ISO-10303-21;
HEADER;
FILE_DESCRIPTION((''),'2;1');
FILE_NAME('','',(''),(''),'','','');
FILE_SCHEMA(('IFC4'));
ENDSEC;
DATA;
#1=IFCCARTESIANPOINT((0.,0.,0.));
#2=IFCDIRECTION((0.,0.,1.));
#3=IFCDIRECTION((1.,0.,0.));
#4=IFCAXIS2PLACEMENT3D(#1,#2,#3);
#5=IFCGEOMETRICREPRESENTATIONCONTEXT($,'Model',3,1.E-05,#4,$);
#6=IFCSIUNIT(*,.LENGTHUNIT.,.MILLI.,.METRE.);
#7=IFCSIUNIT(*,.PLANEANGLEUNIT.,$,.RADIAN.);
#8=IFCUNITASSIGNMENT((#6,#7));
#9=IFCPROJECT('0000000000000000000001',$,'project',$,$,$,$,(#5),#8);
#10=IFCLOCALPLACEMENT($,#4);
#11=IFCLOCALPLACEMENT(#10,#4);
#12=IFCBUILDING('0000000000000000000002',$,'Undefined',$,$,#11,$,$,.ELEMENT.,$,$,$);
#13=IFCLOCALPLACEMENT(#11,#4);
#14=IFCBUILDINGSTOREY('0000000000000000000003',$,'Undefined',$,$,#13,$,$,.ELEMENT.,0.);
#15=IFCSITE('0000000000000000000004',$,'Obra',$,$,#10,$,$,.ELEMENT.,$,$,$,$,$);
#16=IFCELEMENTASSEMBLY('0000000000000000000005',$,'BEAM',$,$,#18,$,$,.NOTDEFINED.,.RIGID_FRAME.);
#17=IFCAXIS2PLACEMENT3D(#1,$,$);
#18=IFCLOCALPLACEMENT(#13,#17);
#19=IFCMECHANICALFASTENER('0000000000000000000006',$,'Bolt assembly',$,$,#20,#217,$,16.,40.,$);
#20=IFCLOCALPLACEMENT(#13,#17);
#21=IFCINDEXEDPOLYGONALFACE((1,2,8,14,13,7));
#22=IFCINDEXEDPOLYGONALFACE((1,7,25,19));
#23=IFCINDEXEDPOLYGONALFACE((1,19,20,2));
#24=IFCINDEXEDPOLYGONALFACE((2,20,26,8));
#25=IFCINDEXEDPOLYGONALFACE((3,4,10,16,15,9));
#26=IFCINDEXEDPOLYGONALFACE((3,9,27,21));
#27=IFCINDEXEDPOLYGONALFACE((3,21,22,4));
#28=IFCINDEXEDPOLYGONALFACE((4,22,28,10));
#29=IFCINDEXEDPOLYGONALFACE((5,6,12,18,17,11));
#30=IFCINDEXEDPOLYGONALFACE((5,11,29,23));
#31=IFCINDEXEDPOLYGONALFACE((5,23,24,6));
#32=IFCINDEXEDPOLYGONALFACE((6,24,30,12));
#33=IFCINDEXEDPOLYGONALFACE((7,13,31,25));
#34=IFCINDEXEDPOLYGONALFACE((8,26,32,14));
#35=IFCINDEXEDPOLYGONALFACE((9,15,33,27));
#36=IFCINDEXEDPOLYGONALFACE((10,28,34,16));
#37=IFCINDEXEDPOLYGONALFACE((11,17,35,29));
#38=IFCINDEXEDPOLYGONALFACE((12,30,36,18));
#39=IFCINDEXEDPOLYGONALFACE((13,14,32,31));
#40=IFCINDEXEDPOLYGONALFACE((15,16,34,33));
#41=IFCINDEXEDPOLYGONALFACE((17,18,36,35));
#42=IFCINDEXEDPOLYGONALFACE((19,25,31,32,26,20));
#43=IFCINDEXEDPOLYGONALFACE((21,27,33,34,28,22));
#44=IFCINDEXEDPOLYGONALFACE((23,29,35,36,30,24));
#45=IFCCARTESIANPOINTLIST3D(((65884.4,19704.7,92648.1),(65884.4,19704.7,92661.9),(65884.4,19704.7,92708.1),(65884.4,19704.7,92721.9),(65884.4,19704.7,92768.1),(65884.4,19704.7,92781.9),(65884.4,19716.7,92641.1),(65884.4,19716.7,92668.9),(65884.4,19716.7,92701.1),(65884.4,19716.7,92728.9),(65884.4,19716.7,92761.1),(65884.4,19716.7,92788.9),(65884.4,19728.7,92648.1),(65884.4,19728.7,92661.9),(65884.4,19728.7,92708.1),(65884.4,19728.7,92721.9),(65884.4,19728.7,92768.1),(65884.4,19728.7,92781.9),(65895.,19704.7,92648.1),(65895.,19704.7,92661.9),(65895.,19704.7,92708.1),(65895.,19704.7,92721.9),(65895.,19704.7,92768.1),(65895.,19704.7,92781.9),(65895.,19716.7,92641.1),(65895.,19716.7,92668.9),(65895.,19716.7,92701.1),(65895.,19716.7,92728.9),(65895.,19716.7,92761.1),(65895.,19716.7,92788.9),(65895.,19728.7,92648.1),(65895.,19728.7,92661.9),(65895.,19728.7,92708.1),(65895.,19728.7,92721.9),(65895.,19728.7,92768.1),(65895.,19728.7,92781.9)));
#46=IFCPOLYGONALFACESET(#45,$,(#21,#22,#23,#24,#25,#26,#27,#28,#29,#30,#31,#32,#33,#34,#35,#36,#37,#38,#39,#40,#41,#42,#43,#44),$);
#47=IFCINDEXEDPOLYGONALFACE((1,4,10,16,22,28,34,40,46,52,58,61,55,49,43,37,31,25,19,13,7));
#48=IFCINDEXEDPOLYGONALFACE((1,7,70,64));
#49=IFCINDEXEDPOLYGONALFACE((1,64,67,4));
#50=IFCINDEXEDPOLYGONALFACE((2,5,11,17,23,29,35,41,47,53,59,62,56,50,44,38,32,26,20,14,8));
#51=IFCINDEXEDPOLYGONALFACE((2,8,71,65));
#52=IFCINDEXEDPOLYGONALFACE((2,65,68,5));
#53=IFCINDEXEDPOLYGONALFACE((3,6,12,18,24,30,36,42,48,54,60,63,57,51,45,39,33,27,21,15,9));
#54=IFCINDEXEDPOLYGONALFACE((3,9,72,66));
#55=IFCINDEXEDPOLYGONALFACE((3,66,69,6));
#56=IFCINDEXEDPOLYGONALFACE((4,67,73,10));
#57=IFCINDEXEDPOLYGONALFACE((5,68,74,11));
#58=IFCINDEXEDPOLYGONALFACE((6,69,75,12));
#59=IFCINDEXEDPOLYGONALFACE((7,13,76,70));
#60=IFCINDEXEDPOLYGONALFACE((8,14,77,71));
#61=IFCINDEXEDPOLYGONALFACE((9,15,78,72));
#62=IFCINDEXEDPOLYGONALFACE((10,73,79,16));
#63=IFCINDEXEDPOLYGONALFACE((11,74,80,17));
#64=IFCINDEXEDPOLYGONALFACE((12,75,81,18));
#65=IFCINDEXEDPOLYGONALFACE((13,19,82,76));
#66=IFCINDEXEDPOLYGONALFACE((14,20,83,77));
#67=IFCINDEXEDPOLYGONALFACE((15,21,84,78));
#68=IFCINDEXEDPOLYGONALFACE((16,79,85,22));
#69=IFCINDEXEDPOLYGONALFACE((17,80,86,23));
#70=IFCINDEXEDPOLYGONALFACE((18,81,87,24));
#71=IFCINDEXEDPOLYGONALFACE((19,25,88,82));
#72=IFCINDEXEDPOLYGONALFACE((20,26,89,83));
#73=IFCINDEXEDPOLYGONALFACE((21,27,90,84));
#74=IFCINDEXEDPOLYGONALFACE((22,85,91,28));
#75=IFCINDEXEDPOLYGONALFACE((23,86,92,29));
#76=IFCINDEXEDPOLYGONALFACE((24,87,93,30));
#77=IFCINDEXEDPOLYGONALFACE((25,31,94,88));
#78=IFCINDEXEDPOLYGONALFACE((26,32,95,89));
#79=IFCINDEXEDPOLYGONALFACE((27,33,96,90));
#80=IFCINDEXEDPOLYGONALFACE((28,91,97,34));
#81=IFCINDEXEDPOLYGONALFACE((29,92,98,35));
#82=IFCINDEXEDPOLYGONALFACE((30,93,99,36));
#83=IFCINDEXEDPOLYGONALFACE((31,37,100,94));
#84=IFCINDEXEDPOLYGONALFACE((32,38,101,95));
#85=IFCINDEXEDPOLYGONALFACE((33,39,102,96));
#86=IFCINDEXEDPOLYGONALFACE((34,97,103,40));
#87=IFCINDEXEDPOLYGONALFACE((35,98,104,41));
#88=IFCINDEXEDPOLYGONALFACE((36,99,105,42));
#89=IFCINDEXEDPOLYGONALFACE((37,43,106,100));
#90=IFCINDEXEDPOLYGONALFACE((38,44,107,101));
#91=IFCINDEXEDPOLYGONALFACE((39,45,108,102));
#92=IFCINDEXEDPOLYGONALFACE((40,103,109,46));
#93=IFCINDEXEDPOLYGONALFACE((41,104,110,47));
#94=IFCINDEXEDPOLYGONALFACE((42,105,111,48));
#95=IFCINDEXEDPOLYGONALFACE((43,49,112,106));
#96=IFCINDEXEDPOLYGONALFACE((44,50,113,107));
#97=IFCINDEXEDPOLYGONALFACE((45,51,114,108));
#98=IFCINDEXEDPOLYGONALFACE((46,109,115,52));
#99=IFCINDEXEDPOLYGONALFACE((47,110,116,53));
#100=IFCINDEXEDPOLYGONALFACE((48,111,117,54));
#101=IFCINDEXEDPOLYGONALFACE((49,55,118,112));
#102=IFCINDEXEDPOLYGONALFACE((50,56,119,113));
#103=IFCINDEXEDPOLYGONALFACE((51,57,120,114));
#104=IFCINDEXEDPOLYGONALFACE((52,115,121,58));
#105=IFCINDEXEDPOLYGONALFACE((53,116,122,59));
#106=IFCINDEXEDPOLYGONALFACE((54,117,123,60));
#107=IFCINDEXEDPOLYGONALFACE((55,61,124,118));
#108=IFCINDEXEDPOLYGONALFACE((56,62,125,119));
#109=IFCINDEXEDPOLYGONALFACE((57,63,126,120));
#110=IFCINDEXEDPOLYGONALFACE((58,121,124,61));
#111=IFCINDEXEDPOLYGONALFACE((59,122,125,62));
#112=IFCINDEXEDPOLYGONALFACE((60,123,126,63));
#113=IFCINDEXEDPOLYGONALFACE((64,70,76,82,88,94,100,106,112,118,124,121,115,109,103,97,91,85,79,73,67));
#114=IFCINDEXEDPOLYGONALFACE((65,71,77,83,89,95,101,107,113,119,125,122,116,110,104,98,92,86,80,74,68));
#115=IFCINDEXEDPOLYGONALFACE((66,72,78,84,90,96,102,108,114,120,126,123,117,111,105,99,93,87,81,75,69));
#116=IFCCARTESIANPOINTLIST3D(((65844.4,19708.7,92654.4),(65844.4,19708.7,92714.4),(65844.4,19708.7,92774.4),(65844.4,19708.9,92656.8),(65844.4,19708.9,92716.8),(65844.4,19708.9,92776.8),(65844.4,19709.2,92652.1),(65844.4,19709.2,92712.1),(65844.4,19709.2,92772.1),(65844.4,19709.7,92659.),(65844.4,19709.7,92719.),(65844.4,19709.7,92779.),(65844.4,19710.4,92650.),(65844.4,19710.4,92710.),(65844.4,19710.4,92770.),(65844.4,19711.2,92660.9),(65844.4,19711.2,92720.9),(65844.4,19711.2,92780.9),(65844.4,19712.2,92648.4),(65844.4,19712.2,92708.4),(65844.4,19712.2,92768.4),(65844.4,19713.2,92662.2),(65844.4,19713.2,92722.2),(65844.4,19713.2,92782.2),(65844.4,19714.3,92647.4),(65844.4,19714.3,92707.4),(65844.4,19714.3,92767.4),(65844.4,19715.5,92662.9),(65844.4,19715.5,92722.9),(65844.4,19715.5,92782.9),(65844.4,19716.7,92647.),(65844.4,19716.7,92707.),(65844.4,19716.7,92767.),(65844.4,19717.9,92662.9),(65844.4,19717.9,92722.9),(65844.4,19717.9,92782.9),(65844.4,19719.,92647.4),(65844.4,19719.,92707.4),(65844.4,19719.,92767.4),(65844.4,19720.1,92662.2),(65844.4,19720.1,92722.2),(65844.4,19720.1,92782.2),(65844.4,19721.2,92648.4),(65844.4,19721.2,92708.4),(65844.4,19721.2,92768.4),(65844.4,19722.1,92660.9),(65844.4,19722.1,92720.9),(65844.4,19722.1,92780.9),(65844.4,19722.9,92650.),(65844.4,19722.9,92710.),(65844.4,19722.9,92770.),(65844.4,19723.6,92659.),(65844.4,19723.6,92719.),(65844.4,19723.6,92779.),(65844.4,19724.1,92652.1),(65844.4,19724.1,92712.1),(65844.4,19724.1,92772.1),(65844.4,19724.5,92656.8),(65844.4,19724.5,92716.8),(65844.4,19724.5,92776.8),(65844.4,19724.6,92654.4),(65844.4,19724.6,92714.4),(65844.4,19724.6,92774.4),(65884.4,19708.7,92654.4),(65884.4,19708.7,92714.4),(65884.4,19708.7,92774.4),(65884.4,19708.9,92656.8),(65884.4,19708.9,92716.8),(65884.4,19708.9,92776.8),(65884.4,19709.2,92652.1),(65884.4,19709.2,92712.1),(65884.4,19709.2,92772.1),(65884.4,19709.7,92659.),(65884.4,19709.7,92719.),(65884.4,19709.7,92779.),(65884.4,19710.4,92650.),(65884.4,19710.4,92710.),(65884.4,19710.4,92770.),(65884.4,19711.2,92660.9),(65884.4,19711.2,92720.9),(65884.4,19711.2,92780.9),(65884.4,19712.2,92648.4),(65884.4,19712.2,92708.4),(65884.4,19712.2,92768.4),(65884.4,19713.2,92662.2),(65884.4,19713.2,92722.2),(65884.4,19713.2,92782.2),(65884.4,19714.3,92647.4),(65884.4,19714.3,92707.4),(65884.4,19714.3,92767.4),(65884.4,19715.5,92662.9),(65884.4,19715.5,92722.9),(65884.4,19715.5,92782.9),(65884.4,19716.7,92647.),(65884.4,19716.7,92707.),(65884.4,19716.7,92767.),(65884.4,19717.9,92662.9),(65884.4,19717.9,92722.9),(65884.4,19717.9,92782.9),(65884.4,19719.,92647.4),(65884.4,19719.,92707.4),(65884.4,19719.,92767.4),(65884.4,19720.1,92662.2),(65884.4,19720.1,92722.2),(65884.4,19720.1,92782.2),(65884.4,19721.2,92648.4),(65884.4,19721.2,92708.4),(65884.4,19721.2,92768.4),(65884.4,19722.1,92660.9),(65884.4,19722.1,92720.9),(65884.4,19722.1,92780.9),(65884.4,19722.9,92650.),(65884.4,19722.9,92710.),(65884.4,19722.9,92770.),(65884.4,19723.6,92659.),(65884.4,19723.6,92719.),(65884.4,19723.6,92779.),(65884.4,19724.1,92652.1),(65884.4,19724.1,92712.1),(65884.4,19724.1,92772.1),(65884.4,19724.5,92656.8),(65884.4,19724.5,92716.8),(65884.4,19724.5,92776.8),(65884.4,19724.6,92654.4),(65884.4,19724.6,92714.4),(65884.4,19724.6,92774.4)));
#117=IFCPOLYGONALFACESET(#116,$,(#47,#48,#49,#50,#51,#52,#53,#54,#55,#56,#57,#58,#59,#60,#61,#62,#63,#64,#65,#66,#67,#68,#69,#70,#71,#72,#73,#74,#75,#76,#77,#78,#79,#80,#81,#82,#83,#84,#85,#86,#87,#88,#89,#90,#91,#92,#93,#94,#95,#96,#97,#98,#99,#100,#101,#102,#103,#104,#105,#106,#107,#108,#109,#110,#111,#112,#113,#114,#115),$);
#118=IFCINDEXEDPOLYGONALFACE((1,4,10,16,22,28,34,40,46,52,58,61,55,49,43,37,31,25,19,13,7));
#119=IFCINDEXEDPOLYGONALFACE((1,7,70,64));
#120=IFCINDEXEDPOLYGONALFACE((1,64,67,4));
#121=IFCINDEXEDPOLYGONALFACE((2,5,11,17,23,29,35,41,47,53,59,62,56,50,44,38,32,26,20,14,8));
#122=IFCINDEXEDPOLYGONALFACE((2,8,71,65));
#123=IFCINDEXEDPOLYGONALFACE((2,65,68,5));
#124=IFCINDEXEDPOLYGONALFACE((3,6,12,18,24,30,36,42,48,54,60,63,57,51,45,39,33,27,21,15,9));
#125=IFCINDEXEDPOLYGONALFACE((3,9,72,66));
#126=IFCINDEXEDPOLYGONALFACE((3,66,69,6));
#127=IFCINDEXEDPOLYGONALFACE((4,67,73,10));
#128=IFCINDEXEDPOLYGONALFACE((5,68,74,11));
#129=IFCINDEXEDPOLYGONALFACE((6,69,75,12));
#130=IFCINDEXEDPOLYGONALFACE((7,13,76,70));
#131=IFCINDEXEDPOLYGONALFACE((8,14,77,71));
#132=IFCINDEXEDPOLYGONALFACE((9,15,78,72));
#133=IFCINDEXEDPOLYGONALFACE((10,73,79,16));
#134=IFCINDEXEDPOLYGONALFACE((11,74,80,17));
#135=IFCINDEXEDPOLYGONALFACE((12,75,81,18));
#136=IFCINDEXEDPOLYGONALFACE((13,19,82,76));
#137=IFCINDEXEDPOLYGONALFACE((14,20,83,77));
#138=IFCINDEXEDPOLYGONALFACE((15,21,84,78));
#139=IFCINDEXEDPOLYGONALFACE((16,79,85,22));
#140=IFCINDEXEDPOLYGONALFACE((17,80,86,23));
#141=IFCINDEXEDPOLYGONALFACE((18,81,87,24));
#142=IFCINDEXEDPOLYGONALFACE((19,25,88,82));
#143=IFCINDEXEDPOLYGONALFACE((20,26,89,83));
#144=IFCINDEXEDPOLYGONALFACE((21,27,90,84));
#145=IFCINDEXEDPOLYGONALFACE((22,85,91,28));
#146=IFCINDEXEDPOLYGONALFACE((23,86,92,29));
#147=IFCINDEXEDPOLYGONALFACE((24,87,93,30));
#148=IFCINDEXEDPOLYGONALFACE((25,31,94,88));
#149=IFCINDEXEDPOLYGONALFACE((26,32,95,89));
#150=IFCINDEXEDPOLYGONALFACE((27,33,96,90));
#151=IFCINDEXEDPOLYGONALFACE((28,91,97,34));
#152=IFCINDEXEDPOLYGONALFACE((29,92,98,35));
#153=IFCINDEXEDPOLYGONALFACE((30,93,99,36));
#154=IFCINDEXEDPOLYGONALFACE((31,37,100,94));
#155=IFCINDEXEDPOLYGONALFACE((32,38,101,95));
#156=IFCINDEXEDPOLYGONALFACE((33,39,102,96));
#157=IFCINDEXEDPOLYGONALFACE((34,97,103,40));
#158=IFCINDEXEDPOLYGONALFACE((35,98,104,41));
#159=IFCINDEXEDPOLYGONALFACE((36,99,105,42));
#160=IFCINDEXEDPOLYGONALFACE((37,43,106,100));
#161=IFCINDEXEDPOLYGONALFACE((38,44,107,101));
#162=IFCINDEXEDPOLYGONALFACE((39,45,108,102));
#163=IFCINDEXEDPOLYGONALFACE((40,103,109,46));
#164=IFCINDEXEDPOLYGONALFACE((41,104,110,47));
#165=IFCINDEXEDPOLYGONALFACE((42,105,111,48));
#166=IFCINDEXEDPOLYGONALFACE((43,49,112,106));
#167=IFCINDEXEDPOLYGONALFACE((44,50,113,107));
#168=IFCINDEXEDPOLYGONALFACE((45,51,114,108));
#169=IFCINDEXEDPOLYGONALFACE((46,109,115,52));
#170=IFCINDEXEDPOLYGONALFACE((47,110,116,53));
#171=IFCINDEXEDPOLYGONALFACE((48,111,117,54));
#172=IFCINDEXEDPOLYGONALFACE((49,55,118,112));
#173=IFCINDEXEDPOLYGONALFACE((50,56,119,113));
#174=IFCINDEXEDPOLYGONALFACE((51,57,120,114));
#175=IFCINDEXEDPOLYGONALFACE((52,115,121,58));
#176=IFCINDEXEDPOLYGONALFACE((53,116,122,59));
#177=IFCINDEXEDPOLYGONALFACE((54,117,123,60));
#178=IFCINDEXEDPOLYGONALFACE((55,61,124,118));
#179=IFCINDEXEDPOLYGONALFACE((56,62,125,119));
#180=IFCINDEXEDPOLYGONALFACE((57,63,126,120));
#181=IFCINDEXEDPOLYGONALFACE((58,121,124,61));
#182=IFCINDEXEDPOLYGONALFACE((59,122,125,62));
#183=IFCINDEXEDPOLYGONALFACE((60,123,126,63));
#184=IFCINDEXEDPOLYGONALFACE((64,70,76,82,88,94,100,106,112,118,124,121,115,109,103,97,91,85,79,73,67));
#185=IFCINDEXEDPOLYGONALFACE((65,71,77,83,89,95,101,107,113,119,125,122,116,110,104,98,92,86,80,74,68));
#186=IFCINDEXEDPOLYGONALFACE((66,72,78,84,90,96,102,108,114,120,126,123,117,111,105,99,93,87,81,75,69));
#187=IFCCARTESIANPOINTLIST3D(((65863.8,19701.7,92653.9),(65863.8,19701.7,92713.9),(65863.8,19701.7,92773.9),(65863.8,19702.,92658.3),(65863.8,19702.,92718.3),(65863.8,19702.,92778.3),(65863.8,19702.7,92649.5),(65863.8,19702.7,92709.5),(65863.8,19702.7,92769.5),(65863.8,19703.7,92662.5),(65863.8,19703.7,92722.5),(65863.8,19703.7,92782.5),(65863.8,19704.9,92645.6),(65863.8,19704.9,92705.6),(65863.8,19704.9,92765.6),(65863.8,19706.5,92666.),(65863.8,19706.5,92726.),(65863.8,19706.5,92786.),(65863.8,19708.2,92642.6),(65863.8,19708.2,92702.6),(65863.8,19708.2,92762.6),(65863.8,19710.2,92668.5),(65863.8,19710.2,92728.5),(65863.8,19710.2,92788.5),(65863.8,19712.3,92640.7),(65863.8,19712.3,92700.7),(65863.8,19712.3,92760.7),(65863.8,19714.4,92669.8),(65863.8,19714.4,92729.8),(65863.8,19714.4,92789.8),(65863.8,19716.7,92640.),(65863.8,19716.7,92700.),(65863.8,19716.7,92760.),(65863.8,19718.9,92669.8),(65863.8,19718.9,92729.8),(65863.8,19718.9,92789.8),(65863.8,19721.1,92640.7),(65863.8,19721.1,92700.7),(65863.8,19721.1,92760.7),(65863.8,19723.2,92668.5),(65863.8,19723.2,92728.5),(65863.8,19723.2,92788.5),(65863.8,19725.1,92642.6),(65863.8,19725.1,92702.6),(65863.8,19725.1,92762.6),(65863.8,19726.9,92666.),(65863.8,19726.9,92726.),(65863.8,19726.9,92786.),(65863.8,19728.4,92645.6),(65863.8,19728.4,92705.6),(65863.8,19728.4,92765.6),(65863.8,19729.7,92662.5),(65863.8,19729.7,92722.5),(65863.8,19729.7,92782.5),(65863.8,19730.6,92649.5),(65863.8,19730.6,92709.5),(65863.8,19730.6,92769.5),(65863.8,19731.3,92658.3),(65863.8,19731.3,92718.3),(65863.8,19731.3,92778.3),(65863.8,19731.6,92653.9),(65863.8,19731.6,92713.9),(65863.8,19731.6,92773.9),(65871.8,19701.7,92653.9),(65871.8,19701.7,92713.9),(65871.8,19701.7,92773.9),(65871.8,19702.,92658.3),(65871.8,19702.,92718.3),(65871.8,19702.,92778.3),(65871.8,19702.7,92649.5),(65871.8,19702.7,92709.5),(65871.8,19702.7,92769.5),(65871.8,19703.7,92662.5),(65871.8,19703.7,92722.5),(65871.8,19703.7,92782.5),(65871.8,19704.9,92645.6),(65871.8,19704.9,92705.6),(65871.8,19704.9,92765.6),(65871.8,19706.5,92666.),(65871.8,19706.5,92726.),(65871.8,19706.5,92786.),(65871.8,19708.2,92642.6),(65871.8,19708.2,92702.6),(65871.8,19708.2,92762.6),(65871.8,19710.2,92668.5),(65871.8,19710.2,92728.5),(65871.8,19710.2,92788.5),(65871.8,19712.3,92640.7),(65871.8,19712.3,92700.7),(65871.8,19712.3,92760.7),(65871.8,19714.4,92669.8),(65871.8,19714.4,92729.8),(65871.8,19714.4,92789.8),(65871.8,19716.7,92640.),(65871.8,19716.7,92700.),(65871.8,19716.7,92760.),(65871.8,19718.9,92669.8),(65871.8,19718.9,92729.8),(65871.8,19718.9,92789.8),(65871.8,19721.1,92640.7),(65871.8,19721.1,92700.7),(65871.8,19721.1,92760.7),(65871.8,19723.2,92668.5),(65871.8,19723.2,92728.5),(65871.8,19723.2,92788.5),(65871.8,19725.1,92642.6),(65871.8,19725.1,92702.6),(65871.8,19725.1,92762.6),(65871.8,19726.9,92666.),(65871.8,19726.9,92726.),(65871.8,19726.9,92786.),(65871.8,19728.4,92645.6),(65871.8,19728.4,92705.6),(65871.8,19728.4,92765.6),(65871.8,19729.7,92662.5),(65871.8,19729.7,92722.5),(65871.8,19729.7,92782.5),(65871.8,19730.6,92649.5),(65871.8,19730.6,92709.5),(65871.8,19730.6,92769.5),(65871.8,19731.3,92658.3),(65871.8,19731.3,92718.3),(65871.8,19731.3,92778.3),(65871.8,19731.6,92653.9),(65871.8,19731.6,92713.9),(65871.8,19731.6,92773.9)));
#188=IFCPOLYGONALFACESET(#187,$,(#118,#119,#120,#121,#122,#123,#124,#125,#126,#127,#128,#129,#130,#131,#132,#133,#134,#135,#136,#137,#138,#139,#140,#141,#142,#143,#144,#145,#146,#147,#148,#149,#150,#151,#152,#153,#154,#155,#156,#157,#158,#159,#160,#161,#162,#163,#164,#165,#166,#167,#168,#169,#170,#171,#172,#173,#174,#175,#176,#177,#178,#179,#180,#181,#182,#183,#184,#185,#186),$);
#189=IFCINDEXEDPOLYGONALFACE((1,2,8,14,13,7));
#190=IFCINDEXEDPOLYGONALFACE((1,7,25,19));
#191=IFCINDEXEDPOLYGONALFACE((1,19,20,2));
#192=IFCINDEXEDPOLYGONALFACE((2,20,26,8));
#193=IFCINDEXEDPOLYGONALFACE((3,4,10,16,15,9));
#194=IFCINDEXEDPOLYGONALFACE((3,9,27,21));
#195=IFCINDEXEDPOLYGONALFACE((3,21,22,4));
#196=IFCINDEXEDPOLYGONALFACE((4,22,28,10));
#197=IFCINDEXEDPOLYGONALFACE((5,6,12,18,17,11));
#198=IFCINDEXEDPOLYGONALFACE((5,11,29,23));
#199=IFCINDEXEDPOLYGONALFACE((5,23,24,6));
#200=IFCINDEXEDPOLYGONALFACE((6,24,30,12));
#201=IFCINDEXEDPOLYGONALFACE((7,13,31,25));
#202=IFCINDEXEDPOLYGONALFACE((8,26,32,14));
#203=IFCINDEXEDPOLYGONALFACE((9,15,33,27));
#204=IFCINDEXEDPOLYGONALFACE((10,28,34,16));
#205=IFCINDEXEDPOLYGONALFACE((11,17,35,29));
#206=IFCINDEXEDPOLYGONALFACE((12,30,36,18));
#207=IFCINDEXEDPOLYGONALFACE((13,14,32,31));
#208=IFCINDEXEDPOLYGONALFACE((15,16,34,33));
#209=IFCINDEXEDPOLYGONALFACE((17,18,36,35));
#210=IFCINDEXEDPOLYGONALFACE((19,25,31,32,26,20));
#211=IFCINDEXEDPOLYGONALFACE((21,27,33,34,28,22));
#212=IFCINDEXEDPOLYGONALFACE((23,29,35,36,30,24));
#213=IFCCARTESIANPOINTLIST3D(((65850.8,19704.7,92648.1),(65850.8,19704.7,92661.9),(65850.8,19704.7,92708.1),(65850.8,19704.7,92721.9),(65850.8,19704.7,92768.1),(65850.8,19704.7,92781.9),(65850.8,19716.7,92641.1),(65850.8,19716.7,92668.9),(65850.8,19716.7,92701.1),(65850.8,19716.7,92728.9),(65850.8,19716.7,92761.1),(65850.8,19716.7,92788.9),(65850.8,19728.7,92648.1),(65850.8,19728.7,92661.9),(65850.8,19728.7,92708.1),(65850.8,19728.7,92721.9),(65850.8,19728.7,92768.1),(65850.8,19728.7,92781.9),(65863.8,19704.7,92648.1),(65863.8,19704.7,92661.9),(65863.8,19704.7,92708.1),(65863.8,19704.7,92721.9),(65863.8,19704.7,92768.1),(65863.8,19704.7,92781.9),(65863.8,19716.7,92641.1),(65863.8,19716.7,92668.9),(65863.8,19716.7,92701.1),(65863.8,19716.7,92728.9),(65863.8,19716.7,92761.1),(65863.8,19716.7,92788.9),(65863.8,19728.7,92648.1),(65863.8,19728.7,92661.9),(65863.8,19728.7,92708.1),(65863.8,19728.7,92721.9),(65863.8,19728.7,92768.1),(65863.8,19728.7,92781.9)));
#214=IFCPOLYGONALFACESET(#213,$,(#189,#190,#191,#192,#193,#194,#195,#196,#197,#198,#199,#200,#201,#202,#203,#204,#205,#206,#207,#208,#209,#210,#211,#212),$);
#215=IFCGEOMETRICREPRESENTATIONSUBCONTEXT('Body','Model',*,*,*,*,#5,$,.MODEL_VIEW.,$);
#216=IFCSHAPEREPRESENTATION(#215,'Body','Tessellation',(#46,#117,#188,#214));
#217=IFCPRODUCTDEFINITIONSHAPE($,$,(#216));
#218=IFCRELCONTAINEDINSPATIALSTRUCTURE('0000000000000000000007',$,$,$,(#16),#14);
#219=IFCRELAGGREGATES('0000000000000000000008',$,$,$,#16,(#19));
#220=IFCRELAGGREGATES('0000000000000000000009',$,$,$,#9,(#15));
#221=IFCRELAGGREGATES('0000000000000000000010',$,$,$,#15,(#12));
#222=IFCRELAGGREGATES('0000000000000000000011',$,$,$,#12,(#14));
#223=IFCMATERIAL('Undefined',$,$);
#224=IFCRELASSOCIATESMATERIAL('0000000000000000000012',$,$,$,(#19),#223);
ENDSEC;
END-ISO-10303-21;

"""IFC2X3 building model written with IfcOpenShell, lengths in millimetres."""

from ifc_helpers import new_model, si_unit, frame, origin_with_axes, origin_2d_with_axis, place, context, subcontext, project, spatial, polyline, circle, outline, extrude, source, transform, mapped, material, element, aggregate, save


model = new_model("IFC2X3")

# Units and contexts
model_context = context("Model", 3, precision=1e-05, world=origin_with_axes())
body_context = subcontext(model_context, "Body", "Model", "MODEL_VIEW")
ifc_project = project(units=[si_unit("LENGTHUNIT", "METRE", prefix="MILLI"), si_unit("PLANEANGLEUNIT", "RADIAN")], contexts=[model_context])

# Site, building, storey
site_placement = place(None, origin_with_axes())
site = spatial("IfcSite", under=ifc_project, at=site_placement, Name="Obra", CompositionType="ELEMENT")
building_placement = place(site_placement, origin_with_axes())
building = spatial("IfcBuilding", under=site, at=building_placement, Name="Undefined", CompositionType="ELEMENT")
storey_placement = place(building_placement, origin_with_axes())
storey = spatial("IfcBuildingStorey", under=building, at=storey_placement, Name="Undefined", CompositionType="ELEMENT", Elevation=0.0)

# Shared definitions
ifc_material_1 = material(Name="Undefined")
shared_shape_1 = source(origin_with_axes(), body_context, "Body", "SweptSolid", [
    extrude(outline(polyline([(13.9, 0.0), (6.9, 12.0), (-6.9, 12.0), (-13.9, 0.0), (-6.9, -12.0), (6.9, -12.0), (13.9, 0.0)])), frame((0.0, -19.9, 0.0), z_axis=(0.0, 1.0, 0.0), x_axis=(1.0, 0.0, 0.0)), (0.0, 0.0, 1.0), 10.6),
    extrude(circle(Radius=8.0, at=origin_2d_with_axis()), frame((0.0, -9.3, 0.0), z_axis=(0.0, 1.0, 0.0), x_axis=(1.0, 0.0, 0.0)), (0.0, 0.0, 1.0), 40.0),
    extrude(circle(Radius=15.0, at=origin_2d_with_axis()), frame((0.0, 3.3, 0.0), z_axis=(0.0, 1.0, 0.0), x_axis=(1.0, 0.0, 0.0)), (0.0, 0.0, 1.0), 8.0),
    extrude(outline(polyline([(13.9, 0.0), (6.9, 12.0), (-6.9, 12.0), (-13.9, 0.0), (-6.9, -12.0), (6.9, -12.0), (13.9, 0.0)])), frame((0.0, 11.3, 0.0), z_axis=(0.0, 1.0, 0.0), x_axis=(1.0, 0.0, 0.0)), (0.0, 0.0, 1.0), 13.0),
])

# Element assembly, mechanical fastener
assembly_1_placement = place(storey_placement, origin_with_axes())
assembly_1 = element("IfcElementAssembly", 1, at=assembly_1_placement, inside=storey, Name="BEAM", AssemblyPlace="NOTDEFINED", PredefinedType="RIGID_FRAME")
mechanical_fastener_1_placement = place(assembly_1_placement, frame((65875.1, 19666.7, 92850.0), z_axis=(-0.000002, 1.0, 0.0), x_axis=(0.0, 0.0, -1.0)))
mechanical_fastener_1 = element("IfcMechanicalFastener", 2, at=mechanical_fastener_1_placement, material=ifc_material_1, Name="Bolt assembly", NominalDiameter=16.0, NominalLength=40.0, context=body_context, shape_type="MappedRepresentation", body=[
    mapped(shared_shape_1, transform((75.0, 0.0, 50.0))),
    mapped(shared_shape_1, transform((135.0, 0.0, 50.0))),
    mapped(shared_shape_1, transform((195.0, 0.0, 50.0))),
])

aggregate(assembly_1, [mechanical_fastener_1])

save(model, "model.ifc")
